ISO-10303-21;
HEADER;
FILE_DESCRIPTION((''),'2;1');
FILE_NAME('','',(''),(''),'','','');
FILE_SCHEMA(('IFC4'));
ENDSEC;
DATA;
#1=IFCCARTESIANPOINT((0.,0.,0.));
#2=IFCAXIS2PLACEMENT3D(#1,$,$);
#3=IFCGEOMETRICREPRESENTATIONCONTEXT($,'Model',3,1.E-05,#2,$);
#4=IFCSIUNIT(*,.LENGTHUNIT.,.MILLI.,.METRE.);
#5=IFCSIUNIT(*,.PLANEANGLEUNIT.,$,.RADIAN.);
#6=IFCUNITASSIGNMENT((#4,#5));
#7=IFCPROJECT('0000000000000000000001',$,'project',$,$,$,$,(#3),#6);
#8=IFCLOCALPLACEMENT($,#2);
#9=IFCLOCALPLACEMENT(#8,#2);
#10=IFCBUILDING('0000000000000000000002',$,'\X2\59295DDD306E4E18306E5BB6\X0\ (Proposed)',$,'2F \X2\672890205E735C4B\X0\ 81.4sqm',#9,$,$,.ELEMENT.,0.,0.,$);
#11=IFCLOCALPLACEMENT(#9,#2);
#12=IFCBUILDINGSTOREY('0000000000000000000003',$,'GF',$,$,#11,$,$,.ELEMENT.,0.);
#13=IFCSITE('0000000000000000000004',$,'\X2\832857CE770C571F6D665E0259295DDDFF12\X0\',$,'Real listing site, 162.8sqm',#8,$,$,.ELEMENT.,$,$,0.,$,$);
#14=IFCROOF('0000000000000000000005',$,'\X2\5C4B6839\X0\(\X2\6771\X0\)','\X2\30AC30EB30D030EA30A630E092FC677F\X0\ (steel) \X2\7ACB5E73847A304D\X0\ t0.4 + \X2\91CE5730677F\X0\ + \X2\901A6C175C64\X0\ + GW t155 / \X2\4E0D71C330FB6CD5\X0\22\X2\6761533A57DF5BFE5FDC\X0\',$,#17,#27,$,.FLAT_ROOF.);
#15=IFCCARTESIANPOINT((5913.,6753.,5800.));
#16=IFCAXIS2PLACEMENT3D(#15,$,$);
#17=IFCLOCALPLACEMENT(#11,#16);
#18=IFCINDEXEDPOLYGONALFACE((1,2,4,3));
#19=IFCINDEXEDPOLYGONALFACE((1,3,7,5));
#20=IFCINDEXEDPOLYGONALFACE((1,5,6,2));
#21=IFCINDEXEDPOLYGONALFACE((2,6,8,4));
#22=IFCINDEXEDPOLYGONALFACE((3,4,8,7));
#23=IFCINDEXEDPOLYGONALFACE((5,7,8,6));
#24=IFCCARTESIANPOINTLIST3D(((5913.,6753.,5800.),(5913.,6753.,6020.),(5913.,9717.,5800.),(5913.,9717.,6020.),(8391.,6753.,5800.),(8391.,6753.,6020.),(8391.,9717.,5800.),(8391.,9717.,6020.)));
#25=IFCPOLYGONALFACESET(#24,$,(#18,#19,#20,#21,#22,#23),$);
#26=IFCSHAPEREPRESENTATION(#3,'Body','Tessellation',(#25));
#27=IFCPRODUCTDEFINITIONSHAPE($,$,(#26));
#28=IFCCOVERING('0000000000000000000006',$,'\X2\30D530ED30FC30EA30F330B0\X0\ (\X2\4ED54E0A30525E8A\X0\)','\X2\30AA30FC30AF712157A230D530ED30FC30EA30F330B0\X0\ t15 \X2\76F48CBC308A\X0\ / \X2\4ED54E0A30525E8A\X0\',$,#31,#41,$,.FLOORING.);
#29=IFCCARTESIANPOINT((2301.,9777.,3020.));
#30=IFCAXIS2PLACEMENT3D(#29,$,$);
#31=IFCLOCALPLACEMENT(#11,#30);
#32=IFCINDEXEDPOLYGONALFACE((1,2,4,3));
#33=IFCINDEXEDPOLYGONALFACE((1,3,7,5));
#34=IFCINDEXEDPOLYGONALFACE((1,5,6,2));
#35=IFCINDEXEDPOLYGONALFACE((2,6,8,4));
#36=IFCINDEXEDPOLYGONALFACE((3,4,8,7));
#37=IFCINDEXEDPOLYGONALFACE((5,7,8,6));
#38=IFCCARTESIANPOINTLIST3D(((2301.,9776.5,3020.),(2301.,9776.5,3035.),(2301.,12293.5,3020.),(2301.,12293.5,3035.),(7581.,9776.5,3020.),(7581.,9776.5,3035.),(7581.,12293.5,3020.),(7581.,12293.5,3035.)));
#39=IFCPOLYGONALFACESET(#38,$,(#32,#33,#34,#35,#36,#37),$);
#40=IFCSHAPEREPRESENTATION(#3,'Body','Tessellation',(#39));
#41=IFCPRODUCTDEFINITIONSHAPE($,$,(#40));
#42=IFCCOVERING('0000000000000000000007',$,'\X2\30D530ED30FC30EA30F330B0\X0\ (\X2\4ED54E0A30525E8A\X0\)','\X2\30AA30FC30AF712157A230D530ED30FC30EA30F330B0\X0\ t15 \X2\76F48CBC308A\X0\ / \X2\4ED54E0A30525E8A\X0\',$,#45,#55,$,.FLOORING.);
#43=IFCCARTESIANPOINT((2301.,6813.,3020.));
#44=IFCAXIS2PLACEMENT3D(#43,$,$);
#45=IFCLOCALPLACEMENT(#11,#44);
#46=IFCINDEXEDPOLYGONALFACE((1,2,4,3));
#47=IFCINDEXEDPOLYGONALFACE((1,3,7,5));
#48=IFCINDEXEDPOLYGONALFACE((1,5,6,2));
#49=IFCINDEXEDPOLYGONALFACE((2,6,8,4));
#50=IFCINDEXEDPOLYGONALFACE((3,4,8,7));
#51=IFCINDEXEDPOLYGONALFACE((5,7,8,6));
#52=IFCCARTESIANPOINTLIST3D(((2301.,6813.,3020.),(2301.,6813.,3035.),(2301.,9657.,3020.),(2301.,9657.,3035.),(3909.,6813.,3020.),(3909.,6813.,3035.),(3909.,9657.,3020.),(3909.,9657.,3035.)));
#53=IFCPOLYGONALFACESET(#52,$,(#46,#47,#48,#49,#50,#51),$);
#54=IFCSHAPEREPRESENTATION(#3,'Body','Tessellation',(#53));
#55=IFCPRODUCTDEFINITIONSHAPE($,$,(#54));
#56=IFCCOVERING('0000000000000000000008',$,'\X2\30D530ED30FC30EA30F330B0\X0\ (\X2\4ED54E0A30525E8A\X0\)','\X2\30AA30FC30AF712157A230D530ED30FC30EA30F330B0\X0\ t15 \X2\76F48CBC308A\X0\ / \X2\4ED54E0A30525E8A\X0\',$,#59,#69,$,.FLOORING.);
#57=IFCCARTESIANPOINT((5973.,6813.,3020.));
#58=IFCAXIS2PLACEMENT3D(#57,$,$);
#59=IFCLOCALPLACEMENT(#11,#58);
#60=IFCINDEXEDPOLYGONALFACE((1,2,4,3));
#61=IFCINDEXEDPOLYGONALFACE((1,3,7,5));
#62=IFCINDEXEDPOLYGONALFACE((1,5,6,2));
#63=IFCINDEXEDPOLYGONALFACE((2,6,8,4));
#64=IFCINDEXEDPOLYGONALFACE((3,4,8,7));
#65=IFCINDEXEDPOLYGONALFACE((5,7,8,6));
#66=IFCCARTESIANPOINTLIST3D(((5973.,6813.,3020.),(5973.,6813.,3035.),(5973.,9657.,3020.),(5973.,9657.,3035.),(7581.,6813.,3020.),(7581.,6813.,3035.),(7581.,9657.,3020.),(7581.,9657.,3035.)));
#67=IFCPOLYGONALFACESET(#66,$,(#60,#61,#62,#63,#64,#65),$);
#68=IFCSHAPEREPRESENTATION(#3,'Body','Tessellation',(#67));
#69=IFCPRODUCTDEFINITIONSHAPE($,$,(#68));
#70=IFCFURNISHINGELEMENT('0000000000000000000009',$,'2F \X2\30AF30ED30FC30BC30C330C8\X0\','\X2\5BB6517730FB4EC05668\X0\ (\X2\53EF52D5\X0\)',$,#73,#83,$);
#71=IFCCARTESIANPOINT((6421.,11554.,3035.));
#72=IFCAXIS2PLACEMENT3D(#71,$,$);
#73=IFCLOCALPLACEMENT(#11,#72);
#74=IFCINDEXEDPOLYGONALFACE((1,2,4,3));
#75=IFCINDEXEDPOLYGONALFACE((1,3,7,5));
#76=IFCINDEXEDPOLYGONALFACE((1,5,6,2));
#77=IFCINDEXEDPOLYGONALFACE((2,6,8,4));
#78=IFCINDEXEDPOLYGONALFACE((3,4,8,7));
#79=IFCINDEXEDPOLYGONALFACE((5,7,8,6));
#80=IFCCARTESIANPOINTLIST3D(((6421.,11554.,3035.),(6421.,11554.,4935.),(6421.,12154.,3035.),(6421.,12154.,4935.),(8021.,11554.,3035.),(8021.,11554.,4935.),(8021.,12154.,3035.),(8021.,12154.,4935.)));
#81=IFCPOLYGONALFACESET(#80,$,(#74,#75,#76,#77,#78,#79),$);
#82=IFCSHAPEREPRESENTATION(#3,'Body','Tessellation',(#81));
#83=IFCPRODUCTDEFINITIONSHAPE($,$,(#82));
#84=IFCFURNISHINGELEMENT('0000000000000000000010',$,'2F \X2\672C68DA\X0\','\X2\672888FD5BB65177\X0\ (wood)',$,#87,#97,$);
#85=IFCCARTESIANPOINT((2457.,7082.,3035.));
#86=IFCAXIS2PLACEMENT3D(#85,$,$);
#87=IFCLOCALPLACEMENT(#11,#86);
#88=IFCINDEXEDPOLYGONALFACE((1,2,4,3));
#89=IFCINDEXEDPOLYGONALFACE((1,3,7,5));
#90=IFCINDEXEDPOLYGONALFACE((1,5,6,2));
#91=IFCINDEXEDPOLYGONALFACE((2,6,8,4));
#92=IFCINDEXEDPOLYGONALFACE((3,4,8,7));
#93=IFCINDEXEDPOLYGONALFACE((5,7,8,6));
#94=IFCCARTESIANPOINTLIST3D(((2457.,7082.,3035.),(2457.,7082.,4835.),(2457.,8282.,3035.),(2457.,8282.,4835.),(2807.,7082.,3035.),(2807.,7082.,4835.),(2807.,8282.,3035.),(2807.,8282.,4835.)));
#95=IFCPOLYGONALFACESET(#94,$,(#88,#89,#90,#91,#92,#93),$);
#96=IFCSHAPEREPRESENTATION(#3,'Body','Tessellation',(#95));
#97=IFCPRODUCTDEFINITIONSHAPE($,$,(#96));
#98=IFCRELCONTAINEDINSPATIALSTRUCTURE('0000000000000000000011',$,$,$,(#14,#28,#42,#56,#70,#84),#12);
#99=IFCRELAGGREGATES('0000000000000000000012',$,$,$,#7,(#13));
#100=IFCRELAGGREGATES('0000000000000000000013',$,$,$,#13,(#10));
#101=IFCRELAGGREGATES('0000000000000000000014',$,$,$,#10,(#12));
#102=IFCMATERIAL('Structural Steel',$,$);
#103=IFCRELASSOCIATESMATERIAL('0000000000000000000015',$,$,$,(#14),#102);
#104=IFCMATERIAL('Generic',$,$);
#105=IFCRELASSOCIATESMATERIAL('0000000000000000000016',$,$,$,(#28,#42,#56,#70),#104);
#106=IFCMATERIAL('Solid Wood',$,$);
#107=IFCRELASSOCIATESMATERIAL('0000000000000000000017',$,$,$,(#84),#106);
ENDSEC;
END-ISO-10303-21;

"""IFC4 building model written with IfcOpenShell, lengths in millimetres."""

from ifc_helpers import new_model, si_unit, frame, frame_2d, origin, place, context, project, spatial, rectangle, extrude, material, element, save


model = new_model("IFC4")

# Units and contexts
model_context = context("Model", 3, precision=1e-05, world=origin())
ifc_project = project(units=[si_unit("LENGTHUNIT", "METRE", prefix="MILLI"), si_unit("PLANEANGLEUNIT", "RADIAN")], contexts=[model_context])

# Site, building, storey
site_placement = place(None, origin())
site = spatial("IfcSite", under=ifc_project, at=site_placement, Name="茨城県土浦市天川２", ObjectType="Real listing site, 162.8sqm", CompositionType="ELEMENT", RefElevation=0.0)
building_placement = place(site_placement, origin())
building = spatial("IfcBuilding", under=site, at=building_placement, Name="天川の丘の家 (Proposed)", ObjectType="2F 木造平屋 81.4sqm", CompositionType="ELEMENT", ElevationOfRefHeight=0.0, ElevationOfTerrain=0.0)
storey_placement = place(building_placement, origin())
storey = spatial("IfcBuildingStorey", under=building, at=storey_placement, Name="GF", CompositionType="ELEMENT", Elevation=0.0)

# Shared definitions
ifc_material_1 = material(Name="Solid Wood")

# Roof
ifc_material_2 = material(Name="Structural Steel")
roof_1_placement = place(storey_placement, frame((5913.0, 6753.0, 5800.0)))
element("IfcRoof", 1, at=roof_1_placement, inside=storey, material=ifc_material_2, Name="屋根(東)", Description="ガルバリウム鋼板 (steel) 立平葺き t0.4 + 野地板 + 通気層 + GW t155 / 不燃・法22条区域対応", PredefinedType="FLAT_ROOF", context=model_context, shape_type="SweptSolid", body=[
    extrude(rectangle(XDim=2478.0, YDim=2964.0, at=frame_2d((1239.0, 1482.0))), frame((5913.0, 6753.0, 5800.0)), (0.0, 0.0, 1.0), 220.0),
])

# Coverings
ifc_material_3 = material(Name="Generic")
covering_1_placement = place(storey_placement, frame((2301.0, 9777.0, 3020.0)))
element("IfcCovering", 2, at=covering_1_placement, inside=storey, material=ifc_material_3, Name="フローリング (仕上げ床)", Description="オーク無垢フローリング t15 直貼り / 仕上げ床", PredefinedType="FLOORING", context=model_context, shape_type="SweptSolid", body=[
    extrude(rectangle(XDim=5280.0, YDim=2517.0, at=frame_2d((2640.0, 1258.0))), frame((2301.0, 9777.0, 3020.0)), (0.0, 0.0, 1.0), 15.0),
])
covering_2_placement = place(storey_placement, frame((2301.0, 6813.0, 3020.0)))
element("IfcCovering", 3, at=covering_2_placement, inside=storey, material=ifc_material_3, Name="フローリング (仕上げ床)", Description="オーク無垢フローリング t15 直貼り / 仕上げ床", PredefinedType="FLOORING", context=model_context, shape_type="SweptSolid", body=[
    extrude(rectangle(XDim=1608.0, YDim=2844.0, at=frame_2d((804.0, 1422.0))), frame((2301.0, 6813.0, 3020.0)), (0.0, 0.0, 1.0), 15.0),
])
covering_3_placement = place(storey_placement, frame((5973.0, 6813.0, 3020.0)))
element("IfcCovering", 4, at=covering_3_placement, inside=storey, material=ifc_material_3, Name="フローリング (仕上げ床)", Description="オーク無垢フローリング t15 直貼り / 仕上げ床", PredefinedType="FLOORING", context=model_context, shape_type="SweptSolid", body=[
    extrude(rectangle(XDim=1608.0, YDim=2844.0, at=frame_2d((804.0, 1422.0))), frame((5973.0, 6813.0, 3020.0)), (0.0, 0.0, 1.0), 15.0),
])

# Furnishing elements
furnishing_1_placement = place(storey_placement, frame((6421.0, 11554.0, 3035.0)))
element("IfcFurnishingElement", 5, at=furnishing_1_placement, inside=storey, material=ifc_material_3, Name="2F クローゼット", Description="家具・什器 (可動)", context=model_context, shape_type="SweptSolid", body=[
    extrude(rectangle(XDim=1600.0, YDim=600.0, at=frame_2d((800.0, 300.0))), frame((6421.0, 11554.0, 3035.0)), (0.0, 0.0, 1.0), 1900.0),
])
furnishing_2_placement = place(storey_placement, frame((2457.0, 7082.0, 3035.0)))
element("IfcFurnishingElement", 6, at=furnishing_2_placement, inside=storey, material=ifc_material_1, Name="2F 本棚", Description="木製家具 (wood)", context=model_context, shape_type="SweptSolid", body=[
    extrude(rectangle(XDim=350.0, YDim=1200.0, at=frame_2d((175.0, 600.0))), frame((2457.0, 7082.0, 3035.0)), (0.0, 0.0, 1.0), 1800.0),
])

save(model, "model.ifc")
